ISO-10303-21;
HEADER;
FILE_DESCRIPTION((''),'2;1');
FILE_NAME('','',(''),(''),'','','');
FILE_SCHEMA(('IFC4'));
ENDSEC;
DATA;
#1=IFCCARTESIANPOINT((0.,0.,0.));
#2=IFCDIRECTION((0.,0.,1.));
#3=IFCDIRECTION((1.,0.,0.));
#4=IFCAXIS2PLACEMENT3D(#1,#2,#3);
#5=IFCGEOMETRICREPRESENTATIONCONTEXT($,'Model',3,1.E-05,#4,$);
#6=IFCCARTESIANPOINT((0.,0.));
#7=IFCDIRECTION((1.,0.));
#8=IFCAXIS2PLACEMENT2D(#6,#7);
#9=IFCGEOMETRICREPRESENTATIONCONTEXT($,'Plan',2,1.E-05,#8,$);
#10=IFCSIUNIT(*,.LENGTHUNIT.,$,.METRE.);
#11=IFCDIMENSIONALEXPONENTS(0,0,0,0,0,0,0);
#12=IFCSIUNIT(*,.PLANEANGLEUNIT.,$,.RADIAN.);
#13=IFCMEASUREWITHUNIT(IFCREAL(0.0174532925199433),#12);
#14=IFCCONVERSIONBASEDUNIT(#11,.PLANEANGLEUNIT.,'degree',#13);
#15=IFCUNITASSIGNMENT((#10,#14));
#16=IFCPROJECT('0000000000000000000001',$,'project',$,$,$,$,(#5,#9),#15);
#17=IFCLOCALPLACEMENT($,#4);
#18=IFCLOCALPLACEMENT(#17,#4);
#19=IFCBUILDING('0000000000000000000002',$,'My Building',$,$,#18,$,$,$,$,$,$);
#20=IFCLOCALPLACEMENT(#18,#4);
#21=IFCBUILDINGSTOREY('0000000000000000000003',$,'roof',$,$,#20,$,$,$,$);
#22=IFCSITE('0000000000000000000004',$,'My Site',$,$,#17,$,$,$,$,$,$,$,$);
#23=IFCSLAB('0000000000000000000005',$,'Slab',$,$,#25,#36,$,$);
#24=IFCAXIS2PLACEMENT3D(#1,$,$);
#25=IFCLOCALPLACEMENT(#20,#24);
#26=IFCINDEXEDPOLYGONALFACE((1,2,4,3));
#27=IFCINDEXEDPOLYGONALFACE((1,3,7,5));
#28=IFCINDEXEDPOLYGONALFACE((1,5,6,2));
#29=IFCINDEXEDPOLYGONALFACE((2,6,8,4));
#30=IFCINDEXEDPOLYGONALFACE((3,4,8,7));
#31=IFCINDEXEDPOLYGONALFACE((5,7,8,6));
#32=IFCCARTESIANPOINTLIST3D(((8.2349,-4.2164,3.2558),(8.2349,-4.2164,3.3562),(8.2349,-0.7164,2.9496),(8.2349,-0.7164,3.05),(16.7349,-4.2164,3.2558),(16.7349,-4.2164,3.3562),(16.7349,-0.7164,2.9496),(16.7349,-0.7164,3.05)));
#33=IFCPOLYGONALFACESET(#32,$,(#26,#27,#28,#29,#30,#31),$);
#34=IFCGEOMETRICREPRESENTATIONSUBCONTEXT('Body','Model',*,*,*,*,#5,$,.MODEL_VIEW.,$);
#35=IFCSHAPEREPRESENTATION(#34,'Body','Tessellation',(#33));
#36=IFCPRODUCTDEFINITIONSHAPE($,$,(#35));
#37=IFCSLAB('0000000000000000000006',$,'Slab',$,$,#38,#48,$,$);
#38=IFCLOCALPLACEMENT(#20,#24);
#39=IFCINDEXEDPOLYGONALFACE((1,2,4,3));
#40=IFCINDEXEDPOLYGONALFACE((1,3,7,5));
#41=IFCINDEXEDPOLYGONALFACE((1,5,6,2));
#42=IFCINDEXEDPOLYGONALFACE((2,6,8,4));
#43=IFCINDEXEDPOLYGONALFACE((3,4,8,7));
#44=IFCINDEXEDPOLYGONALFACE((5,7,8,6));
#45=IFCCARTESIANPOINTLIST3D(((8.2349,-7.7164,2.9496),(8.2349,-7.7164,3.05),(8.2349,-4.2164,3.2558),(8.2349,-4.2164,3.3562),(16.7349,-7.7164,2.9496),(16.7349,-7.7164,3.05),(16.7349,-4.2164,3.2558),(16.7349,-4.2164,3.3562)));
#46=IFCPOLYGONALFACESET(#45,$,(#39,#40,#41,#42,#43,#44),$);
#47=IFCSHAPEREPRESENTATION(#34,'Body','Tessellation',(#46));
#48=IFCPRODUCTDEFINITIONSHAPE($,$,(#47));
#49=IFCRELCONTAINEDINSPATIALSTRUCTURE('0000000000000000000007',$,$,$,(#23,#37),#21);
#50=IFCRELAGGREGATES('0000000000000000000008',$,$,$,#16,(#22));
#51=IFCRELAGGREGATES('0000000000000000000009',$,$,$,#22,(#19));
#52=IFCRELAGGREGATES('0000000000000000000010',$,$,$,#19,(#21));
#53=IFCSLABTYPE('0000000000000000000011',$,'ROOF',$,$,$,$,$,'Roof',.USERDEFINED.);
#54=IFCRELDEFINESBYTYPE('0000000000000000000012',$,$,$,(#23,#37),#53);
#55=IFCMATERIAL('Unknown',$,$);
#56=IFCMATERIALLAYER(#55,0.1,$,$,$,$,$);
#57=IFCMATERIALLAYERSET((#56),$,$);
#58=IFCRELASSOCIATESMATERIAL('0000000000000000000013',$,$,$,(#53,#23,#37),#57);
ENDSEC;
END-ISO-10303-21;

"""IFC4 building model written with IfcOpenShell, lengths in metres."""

from ifc_helpers import new_model, entity, si_unit, converted_unit, frame, origin_with_axes, origin_2d_with_axis, place, context, subcontext, project, spatial, indexed_curve, outline, extrude, material, layer, layer_set, layer_usage, type_object, element, save


model = new_model("IFC4")

# Units and contexts
model_context = context("Model", 3, precision=1e-05, world=origin_with_axes())
plan_context = context("Plan", 2, precision=1e-05, world=origin_2d_with_axis())
body_context = subcontext(model_context, "Body", "Model", "MODEL_VIEW")
ifc_project = project(units=[si_unit("LENGTHUNIT", "METRE"), converted_unit("PLANEANGLEUNIT", "degree", entity("IfcReal", 0.0174532925199433), si_unit("PLANEANGLEUNIT", "RADIAN"), dimensions=[0, 0, 0, 0, 0, 0, 0])], contexts=[model_context, plan_context])

# Site, building, storey
site_placement = place(None, origin_with_axes())
site = spatial("IfcSite", under=ifc_project, at=site_placement, Name="My Site")
building_placement = place(site_placement, origin_with_axes())
building = spatial("IfcBuilding", under=site, at=building_placement, Name="My Building")
storey_placement = place(building_placement, origin_with_axes())
storey = spatial("IfcBuildingStorey", under=building, at=storey_placement, Name="roof")

# Slabs
ifc_material = material(Name="Unknown")
ifc_layer = layer(ifc_material, 0.1)
ifc_layer_set = layer_set([ifc_layer])
ifc_layer_usage_1 = layer_usage(ifc_layer_set, "AXIS3", "POSITIVE", -0.1)
slab_type = type_object("IfcSlabType", Name="ROOF", ElementType="Roof", PredefinedType="USERDEFINED", material=ifc_layer_set)
slab_1_placement = place(storey_placement, frame((8.2349, -0.7164, 3.05), z_axis=(0.0, 0.087156, 0.996195), x_axis=(1.0, 0.0, 0.0)))
element("IfcSlab", 1, at=slab_1_placement, inside=storey, type_object=slab_type, material=ifc_layer_usage_1, Name="Slab", context=body_context, shape_type="SweptSolid", body=[
    extrude(outline(indexed_curve([(8.5, 0.0), (8.5, -3.5134), (0.0, -3.5134), (0.0, 0.0), (8.5, 0.0)])), frame((0.0, 0.0087, -0.1), z_axis=(0.0, 0.0, 1.0), x_axis=(1.0, 0.0, 0.0)), (0.0, -0.087156, 0.996195), 0.1004),
])
ifc_layer_usage_2 = layer_usage(ifc_layer_set, "AXIS3", "POSITIVE", -0.1)
slab_2_placement = place(storey_placement, frame((16.7349, -7.7164, 3.05), z_axis=(0.0, -0.087156, 0.996195), x_axis=(-1.0, 0.0, 0.0)))
element("IfcSlab", 2, at=slab_2_placement, inside=storey, type_object=slab_type, material=ifc_layer_usage_2, Name="Slab", context=body_context, shape_type="SweptSolid", body=[
    extrude(outline(indexed_curve([(0.0, 0.0), (0.0, -3.5134), (8.5, -3.5134), (8.5, 0.0), (0.0, 0.0)])), frame((0.0, 0.0087, -0.1), z_axis=(0.0, 0.0, 1.0), x_axis=(1.0, 0.0, 0.0)), (0.0, -0.087156, 0.996195), 0.1004),
])

save(model, "model.ifc")
